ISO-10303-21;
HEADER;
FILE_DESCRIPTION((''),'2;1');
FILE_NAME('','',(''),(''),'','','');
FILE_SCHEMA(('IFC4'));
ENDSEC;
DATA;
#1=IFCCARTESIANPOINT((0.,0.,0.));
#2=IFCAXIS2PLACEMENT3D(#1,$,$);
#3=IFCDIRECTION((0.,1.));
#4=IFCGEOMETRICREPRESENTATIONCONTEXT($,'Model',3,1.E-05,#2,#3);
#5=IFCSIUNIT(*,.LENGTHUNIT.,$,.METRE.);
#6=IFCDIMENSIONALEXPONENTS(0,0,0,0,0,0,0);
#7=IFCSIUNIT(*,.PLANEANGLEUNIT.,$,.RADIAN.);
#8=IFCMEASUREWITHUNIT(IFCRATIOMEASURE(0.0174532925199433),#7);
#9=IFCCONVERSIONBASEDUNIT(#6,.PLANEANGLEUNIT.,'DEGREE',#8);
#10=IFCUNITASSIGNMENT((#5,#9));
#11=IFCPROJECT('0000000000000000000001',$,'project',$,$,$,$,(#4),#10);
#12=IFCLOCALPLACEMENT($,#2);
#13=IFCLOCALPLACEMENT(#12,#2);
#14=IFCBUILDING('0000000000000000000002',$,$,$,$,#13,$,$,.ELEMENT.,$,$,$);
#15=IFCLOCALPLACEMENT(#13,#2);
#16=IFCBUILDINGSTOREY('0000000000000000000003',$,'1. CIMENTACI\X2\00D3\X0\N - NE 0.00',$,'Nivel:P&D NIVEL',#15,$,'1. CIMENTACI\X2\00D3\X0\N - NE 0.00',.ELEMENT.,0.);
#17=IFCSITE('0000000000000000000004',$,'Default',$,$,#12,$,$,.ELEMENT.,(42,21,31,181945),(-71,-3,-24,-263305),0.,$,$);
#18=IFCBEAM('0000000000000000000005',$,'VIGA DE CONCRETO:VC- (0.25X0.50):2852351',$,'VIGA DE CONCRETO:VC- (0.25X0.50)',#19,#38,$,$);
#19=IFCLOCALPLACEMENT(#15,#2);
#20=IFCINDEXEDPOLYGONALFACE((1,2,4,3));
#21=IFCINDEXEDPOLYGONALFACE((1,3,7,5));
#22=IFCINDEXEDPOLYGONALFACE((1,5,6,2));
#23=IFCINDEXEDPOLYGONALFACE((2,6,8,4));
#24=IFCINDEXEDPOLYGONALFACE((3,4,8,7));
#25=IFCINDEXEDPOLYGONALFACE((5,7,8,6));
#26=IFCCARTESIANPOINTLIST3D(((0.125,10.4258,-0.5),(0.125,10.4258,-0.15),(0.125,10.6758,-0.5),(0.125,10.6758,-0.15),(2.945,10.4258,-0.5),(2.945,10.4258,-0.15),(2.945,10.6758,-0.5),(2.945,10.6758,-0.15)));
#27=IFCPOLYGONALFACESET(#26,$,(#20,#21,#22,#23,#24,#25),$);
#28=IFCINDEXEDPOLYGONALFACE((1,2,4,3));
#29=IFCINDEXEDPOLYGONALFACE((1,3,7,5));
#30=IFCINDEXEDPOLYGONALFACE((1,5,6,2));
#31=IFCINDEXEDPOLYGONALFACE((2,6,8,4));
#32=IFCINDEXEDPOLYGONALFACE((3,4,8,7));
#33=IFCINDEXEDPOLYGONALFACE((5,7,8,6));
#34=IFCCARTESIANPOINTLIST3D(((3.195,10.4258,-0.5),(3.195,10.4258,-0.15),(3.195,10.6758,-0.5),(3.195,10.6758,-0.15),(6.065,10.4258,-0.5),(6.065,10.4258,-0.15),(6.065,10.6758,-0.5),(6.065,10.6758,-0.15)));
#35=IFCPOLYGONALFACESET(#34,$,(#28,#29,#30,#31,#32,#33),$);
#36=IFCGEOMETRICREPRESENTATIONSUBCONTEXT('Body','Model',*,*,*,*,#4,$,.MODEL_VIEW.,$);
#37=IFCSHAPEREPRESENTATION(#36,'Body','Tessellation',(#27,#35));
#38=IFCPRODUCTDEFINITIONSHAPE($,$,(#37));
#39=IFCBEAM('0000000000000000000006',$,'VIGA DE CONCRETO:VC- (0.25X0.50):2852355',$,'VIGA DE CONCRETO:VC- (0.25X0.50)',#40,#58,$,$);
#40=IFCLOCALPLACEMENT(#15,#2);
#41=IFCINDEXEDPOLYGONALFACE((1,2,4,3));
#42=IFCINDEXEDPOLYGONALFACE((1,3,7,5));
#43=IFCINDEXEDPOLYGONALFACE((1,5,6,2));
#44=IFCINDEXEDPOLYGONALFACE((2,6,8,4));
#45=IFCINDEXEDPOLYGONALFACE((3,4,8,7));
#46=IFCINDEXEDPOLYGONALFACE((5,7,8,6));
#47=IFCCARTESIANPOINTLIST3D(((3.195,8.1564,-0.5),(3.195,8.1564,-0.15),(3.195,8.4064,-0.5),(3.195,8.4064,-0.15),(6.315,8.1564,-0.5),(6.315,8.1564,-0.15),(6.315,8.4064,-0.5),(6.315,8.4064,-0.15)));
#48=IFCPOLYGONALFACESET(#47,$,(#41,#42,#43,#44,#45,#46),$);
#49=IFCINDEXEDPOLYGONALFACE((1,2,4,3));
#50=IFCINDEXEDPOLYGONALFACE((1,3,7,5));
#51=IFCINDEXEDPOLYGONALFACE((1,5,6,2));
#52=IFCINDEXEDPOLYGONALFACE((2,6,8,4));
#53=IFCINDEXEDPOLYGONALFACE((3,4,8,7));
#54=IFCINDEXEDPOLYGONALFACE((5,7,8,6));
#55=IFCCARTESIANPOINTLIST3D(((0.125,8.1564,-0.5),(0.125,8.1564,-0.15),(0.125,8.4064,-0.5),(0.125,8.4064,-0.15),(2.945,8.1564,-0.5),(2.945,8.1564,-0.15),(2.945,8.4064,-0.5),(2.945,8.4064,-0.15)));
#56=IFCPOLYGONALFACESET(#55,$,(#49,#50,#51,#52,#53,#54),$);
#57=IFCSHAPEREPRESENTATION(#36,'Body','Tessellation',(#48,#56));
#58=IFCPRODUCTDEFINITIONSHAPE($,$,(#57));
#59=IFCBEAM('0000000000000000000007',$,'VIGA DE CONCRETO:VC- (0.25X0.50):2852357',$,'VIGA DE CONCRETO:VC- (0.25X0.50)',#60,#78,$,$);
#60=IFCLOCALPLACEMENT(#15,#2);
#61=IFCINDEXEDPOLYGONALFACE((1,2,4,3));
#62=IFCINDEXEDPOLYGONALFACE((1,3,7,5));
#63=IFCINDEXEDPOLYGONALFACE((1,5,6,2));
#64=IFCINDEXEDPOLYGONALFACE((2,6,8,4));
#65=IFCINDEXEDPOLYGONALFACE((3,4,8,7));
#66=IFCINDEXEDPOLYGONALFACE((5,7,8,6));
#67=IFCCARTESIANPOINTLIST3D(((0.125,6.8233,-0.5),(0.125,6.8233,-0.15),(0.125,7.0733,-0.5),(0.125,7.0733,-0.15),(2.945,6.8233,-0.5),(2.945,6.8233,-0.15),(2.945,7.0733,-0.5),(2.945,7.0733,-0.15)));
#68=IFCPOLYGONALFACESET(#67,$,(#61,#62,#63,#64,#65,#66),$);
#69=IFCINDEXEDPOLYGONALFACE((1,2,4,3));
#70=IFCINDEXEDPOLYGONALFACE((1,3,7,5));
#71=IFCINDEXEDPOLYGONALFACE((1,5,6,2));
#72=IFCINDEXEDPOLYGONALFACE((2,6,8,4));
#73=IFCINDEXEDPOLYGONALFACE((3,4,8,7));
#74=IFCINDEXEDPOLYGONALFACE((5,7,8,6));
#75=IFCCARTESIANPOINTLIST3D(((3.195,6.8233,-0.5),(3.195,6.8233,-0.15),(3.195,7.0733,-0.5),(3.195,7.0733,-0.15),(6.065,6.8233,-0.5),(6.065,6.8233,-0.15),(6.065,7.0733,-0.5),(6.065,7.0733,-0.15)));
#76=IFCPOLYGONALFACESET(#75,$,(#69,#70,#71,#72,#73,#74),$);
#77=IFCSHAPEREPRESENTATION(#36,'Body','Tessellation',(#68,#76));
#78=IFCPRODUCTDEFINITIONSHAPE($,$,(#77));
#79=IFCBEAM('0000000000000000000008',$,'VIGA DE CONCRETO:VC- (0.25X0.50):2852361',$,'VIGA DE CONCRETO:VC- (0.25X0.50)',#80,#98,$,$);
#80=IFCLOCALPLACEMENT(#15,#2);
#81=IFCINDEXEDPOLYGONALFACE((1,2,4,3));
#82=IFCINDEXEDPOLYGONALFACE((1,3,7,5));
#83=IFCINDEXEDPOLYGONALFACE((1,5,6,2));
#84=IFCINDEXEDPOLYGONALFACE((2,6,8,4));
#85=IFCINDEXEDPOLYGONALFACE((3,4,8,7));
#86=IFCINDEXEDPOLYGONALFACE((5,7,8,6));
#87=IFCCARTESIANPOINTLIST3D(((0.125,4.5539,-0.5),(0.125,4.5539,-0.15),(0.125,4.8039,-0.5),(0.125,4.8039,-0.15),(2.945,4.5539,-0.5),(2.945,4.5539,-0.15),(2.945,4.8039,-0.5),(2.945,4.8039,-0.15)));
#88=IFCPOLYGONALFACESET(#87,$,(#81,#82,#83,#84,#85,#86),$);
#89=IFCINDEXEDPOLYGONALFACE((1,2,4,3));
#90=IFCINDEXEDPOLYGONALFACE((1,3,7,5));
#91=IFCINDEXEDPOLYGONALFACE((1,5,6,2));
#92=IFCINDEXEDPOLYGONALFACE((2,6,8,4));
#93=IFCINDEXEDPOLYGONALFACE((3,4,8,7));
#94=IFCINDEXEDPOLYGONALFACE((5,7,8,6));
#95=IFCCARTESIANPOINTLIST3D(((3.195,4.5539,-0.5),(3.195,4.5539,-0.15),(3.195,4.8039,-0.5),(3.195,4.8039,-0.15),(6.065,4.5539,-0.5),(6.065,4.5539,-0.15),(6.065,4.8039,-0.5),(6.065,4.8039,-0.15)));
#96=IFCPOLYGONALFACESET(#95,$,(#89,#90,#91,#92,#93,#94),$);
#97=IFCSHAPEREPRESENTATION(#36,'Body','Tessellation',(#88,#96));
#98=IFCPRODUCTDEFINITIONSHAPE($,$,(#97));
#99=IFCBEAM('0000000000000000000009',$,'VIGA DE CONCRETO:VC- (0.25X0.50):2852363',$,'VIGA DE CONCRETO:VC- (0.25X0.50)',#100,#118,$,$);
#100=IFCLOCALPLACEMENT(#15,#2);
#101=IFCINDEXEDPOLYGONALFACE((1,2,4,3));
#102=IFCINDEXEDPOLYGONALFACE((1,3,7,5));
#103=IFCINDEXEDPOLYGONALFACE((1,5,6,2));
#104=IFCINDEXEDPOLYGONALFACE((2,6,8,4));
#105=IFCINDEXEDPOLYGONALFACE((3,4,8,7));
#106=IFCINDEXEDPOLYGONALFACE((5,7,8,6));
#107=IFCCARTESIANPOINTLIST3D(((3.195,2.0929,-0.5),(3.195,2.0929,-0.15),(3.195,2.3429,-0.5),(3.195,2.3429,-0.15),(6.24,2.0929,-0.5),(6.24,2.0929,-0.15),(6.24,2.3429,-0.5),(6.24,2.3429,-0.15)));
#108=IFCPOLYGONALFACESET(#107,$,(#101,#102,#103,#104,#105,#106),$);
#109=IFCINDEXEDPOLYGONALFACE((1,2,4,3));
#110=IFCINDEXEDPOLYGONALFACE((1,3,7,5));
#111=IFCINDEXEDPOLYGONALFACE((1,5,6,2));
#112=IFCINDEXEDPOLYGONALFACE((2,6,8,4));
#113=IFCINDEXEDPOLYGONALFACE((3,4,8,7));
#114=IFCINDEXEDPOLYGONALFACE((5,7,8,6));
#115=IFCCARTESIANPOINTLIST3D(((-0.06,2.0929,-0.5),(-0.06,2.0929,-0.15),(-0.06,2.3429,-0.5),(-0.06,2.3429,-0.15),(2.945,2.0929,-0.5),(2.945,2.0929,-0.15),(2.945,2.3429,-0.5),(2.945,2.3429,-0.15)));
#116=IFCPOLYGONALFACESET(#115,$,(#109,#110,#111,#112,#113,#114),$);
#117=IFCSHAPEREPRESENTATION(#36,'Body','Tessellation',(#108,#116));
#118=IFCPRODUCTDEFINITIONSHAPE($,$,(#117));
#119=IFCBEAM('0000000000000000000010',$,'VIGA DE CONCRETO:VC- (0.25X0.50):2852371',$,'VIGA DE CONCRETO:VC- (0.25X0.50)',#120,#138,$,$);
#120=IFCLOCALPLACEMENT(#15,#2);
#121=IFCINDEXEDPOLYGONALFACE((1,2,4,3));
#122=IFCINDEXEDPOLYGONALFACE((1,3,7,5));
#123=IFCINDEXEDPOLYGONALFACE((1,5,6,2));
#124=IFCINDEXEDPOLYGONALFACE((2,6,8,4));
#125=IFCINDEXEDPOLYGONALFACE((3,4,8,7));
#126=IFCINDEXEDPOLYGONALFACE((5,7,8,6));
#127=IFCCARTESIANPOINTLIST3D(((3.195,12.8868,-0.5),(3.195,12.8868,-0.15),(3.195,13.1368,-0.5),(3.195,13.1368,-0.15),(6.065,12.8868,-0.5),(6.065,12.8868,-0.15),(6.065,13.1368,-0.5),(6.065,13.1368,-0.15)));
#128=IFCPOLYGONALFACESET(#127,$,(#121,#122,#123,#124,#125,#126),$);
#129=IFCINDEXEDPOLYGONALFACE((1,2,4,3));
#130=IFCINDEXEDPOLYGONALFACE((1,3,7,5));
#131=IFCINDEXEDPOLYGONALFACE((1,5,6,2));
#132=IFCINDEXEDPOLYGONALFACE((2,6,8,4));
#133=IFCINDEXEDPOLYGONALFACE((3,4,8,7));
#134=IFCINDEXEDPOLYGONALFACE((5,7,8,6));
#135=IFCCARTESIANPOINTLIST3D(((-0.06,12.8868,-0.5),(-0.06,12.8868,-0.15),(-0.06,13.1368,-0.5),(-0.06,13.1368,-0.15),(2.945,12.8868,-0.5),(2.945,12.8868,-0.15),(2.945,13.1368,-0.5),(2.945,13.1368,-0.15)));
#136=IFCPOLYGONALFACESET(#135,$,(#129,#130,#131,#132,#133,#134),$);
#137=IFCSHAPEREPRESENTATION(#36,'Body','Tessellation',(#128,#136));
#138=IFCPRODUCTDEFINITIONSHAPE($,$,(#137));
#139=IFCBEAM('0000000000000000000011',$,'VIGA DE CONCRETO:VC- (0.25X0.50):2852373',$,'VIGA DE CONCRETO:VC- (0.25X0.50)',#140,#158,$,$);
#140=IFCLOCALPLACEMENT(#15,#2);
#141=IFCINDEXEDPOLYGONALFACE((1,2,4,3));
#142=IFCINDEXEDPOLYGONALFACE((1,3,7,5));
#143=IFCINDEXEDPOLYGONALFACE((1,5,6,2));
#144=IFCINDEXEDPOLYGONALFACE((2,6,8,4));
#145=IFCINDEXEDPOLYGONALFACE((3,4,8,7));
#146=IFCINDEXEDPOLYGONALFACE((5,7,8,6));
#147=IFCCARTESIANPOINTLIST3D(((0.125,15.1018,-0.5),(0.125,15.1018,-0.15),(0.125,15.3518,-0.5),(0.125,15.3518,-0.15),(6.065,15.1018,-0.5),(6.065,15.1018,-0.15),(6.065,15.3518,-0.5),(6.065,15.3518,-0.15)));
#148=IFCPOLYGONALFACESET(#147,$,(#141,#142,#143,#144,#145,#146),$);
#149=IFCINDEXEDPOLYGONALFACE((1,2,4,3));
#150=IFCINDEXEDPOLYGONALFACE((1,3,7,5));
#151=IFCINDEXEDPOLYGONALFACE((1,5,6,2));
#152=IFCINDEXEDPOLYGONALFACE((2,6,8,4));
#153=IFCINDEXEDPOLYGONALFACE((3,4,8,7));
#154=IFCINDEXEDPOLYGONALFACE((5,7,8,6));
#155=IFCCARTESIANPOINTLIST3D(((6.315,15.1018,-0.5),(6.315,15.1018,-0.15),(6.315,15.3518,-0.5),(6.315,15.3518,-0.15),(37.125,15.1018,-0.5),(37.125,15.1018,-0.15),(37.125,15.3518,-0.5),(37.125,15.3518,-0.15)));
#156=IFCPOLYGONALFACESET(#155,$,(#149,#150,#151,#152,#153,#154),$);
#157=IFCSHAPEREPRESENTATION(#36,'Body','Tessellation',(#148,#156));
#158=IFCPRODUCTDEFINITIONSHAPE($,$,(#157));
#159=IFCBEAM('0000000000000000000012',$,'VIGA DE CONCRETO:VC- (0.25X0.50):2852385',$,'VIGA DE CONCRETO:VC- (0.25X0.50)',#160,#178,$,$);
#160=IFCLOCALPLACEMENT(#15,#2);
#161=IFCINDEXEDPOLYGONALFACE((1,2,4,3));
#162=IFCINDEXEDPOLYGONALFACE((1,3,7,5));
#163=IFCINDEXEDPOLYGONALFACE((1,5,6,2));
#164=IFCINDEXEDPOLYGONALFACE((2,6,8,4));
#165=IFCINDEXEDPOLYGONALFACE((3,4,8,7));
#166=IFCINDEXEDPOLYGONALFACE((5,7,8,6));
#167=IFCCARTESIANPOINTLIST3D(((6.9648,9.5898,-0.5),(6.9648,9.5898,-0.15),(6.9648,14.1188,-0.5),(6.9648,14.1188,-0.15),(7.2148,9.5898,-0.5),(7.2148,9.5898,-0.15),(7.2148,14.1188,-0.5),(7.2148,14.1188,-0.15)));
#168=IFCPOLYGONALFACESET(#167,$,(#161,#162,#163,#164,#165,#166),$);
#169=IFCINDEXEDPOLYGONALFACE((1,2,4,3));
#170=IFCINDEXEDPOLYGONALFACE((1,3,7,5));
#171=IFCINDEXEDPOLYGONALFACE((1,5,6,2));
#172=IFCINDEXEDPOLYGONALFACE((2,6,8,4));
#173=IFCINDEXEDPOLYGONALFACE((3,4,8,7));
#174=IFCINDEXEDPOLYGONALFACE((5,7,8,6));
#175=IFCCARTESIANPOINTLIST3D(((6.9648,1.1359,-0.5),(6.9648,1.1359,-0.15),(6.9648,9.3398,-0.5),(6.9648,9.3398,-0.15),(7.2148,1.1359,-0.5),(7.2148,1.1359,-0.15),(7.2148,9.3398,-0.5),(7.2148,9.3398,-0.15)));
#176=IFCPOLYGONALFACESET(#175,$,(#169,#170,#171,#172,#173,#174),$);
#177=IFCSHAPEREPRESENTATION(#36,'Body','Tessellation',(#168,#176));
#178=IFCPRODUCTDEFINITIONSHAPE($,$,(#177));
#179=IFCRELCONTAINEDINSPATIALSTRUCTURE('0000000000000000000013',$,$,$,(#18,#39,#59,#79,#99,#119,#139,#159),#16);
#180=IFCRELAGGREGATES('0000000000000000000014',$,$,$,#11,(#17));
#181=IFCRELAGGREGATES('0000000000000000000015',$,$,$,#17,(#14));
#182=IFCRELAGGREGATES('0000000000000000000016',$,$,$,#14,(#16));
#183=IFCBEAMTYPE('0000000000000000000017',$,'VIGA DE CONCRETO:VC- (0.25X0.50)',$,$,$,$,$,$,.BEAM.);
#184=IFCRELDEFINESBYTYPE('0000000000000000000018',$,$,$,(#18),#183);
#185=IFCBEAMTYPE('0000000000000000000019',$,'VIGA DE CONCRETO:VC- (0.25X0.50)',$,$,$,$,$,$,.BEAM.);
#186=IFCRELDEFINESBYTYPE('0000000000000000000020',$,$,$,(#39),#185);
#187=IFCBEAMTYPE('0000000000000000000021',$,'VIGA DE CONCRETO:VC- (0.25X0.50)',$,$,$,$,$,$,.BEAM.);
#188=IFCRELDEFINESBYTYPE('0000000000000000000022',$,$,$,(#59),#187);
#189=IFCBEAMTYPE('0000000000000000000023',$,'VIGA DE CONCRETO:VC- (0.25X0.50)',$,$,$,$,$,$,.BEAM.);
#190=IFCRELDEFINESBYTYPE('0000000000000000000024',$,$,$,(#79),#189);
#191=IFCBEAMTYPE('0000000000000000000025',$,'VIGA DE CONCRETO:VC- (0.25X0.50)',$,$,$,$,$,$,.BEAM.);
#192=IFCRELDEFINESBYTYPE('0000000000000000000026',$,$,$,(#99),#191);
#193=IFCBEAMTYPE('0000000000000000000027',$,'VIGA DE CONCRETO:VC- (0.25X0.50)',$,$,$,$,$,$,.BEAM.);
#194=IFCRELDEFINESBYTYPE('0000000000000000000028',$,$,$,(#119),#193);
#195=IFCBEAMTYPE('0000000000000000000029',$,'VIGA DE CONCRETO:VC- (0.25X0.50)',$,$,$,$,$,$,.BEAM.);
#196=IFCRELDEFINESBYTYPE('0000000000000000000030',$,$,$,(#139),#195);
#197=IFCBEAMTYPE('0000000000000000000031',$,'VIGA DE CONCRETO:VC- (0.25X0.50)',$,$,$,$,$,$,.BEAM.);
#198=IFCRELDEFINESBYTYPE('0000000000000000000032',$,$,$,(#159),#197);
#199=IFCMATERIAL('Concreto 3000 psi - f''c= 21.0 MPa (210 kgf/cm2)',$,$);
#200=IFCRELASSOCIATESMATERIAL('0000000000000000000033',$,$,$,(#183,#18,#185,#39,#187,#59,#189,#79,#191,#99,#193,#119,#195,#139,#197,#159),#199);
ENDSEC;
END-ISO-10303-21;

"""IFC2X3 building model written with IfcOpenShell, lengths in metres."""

from ifc_helpers import new_model, entity, si_unit, converted_unit, direction, frame, frame_2d, origin, place, context, subcontext, project, spatial, rectangle, extrude, source, transform, mapped, material, type_object, type_shapes, element, save


model = new_model("IFC2X3")

# Units and contexts
model_context = context("Model", 3, precision=1e-05, world=origin(), true_north=direction((0.0, 1.0)))
body_context = subcontext(model_context, "Body", "Model", "MODEL_VIEW")
ifc_project = project(units=[si_unit("LENGTHUNIT", "METRE"), converted_unit("PLANEANGLEUNIT", "DEGREE", entity("IfcRatioMeasure", 0.0174532925199433), si_unit("PLANEANGLEUNIT", "RADIAN"), dimensions=[0, 0, 0, 0, 0, 0, 0])], contexts=[model_context])

# Site, building, storey
site_placement = place(None, origin())
site = spatial("IfcSite", under=ifc_project, at=site_placement, Name="Default", CompositionType="ELEMENT", RefLatitude=(42, 21, 31, 181945), RefLongitude=(-71, -3, -24, -263305), RefElevation=0.0)
building_placement = place(site_placement, origin())
building = spatial("IfcBuilding", under=site, at=building_placement, CompositionType="ELEMENT")
storey_placement = place(building_placement, origin())
storey = spatial("IfcBuildingStorey", under=building, at=storey_placement, Name="1. CIMENTACIÓN - NE 0.00", ObjectType="Nivel:P&D NIVEL", LongName="1. CIMENTACIÓN - NE 0.00", CompositionType="ELEMENT", Elevation=0.0)

# Beams
ifc_material = material(Name="Concreto 3000 psi - f'c= 21.0 MPa (210 kgf/cm2)")
beam_type_1 = type_object("IfcBeamType", Name="VIGA DE CONCRETO:VC- (0.25X0.50)", PredefinedType="BEAM", material=ifc_material)
shared_shape_1 = source(origin(), body_context, "Body", "SweptSolid", [
    extrude(rectangle(XDim=0.35, YDim=0.25, at=frame_2d((0.0, 0.0), x_axis=(1.0, 0.0))), frame((0.125, 10.5508, -0.325), z_axis=(1.0, 0.0, 0.0), x_axis=(0.0, 0.0, -1.0)), (0.0, 0.0, 1.0), 2.82),
    extrude(rectangle(XDim=0.35, YDim=0.25, at=frame_2d((0.0, 0.0), x_axis=(1.0, 0.0))), frame((3.195, 10.5508, -0.325), z_axis=(1.0, 0.0, 0.0), x_axis=(0.0, 0.0, -1.0)), (0.0, 0.0, 1.0), 2.87),
])
type_shapes(beam_type_1, [shared_shape_1])
beam_1_placement = place(storey_placement, origin())
element("IfcBeam", 1, at=beam_1_placement, inside=storey, type_object=beam_type_1, material=ifc_material, Name="VIGA DE CONCRETO:VC- (0.25X0.50):2852351", ObjectType="VIGA DE CONCRETO:VC- (0.25X0.50)", context=body_context, shape_type="MappedRepresentation", body=[
    mapped(shared_shape_1, transform((0.0, 0.0, 0.0), scale=1.0)),
])
beam_type_2 = type_object("IfcBeamType", Name="VIGA DE CONCRETO:VC- (0.25X0.50)", PredefinedType="BEAM", material=ifc_material)
shared_shape_2 = source(origin(), body_context, "Body", "SweptSolid", [
    extrude(rectangle(XDim=0.35, YDim=0.25, at=frame_2d((0.0, 0.0), x_axis=(1.0, 0.0))), frame((3.195, 8.2814, -0.325), z_axis=(1.0, 0.0, 0.0), x_axis=(0.0, 0.0, -1.0)), (0.0, 0.0, 1.0), 3.12),
    extrude(rectangle(XDim=0.35, YDim=0.25, at=frame_2d((0.0, 0.0), x_axis=(1.0, 0.0))), frame((0.125, 8.2814, -0.325), z_axis=(1.0, 0.0, 0.0), x_axis=(0.0, 0.0, -1.0)), (0.0, 0.0, 1.0), 2.82),
])
type_shapes(beam_type_2, [shared_shape_2])
beam_2_placement = place(storey_placement, origin())
element("IfcBeam", 2, at=beam_2_placement, inside=storey, type_object=beam_type_2, material=ifc_material, Name="VIGA DE CONCRETO:VC- (0.25X0.50):2852355", ObjectType="VIGA DE CONCRETO:VC- (0.25X0.50)", context=body_context, shape_type="MappedRepresentation", body=[
    mapped(shared_shape_2, transform((0.0, 0.0, 0.0), scale=1.0)),
])
beam_type_3 = type_object("IfcBeamType", Name="VIGA DE CONCRETO:VC- (0.25X0.50)", PredefinedType="BEAM", material=ifc_material)
shared_shape_3 = source(origin(), body_context, "Body", "SweptSolid", [
    extrude(rectangle(XDim=0.35, YDim=0.25, at=frame_2d((0.0, 0.0), x_axis=(1.0, 0.0))), frame((0.125, 6.9483, -0.325), z_axis=(1.0, 0.0, 0.0), x_axis=(0.0, 0.0, -1.0)), (0.0, 0.0, 1.0), 2.82),
    extrude(rectangle(XDim=0.35, YDim=0.25, at=frame_2d((0.0, 0.0), x_axis=(1.0, 0.0))), frame((3.195, 6.9483, -0.325), z_axis=(1.0, 0.0, 0.0), x_axis=(0.0, 0.0, -1.0)), (0.0, 0.0, 1.0), 2.87),
])
type_shapes(beam_type_3, [shared_shape_3])
beam_3_placement = place(storey_placement, origin())
element("IfcBeam", 3, at=beam_3_placement, inside=storey, type_object=beam_type_3, material=ifc_material, Name="VIGA DE CONCRETO:VC- (0.25X0.50):2852357", ObjectType="VIGA DE CONCRETO:VC- (0.25X0.50)", context=body_context, shape_type="MappedRepresentation", body=[
    mapped(shared_shape_3, transform((0.0, 0.0, 0.0), scale=1.0)),
])
beam_type_4 = type_object("IfcBeamType", Name="VIGA DE CONCRETO:VC- (0.25X0.50)", PredefinedType="BEAM", material=ifc_material)
shared_shape_4 = source(origin(), body_context, "Body", "SweptSolid", [
    extrude(rectangle(XDim=0.35, YDim=0.25, at=frame_2d((0.0, 0.0), x_axis=(1.0, 0.0))), frame((0.125, 4.6789, -0.325), z_axis=(1.0, 0.0, 0.0), x_axis=(0.0, 0.0, -1.0)), (0.0, 0.0, 1.0), 2.82),
    extrude(rectangle(XDim=0.35, YDim=0.25, at=frame_2d((0.0, 0.0), x_axis=(1.0, 0.0))), frame((3.195, 4.6789, -0.325), z_axis=(1.0, 0.0, 0.0), x_axis=(0.0, 0.0, -1.0)), (0.0, 0.0, 1.0), 2.87),
])
type_shapes(beam_type_4, [shared_shape_4])
beam_4_placement = place(storey_placement, origin())
element("IfcBeam", 4, at=beam_4_placement, inside=storey, type_object=beam_type_4, material=ifc_material, Name="VIGA DE CONCRETO:VC- (0.25X0.50):2852361", ObjectType="VIGA DE CONCRETO:VC- (0.25X0.50)", context=body_context, shape_type="MappedRepresentation", body=[
    mapped(shared_shape_4, transform((0.0, 0.0, 0.0), scale=1.0)),
])
beam_type_5 = type_object("IfcBeamType", Name="VIGA DE CONCRETO:VC- (0.25X0.50)", PredefinedType="BEAM", material=ifc_material)
shared_shape_5 = source(origin(), body_context, "Body", "SweptSolid", [
    extrude(rectangle(XDim=0.35, YDim=0.25, at=frame_2d((0.0, 0.0), x_axis=(1.0, 0.0))), frame((3.195, 2.2179, -0.325), z_axis=(1.0, 0.0, 0.0), x_axis=(0.0, 0.0, -1.0)), (0.0, 0.0, 1.0), 3.045),
    extrude(rectangle(XDim=0.35, YDim=0.25, at=frame_2d((0.0, 0.0), x_axis=(1.0, 0.0))), frame((-0.06, 2.2179, -0.325), z_axis=(1.0, 0.0, 0.0), x_axis=(0.0, 0.0, -1.0)), (0.0, 0.0, 1.0), 3.005),
])
type_shapes(beam_type_5, [shared_shape_5])
beam_5_placement = place(storey_placement, origin())
element("IfcBeam", 5, at=beam_5_placement, inside=storey, type_object=beam_type_5, material=ifc_material, Name="VIGA DE CONCRETO:VC- (0.25X0.50):2852363", ObjectType="VIGA DE CONCRETO:VC- (0.25X0.50)", context=body_context, shape_type="MappedRepresentation", body=[
    mapped(shared_shape_5, transform((0.0, 0.0, 0.0), scale=1.0)),
])
beam_type_6 = type_object("IfcBeamType", Name="VIGA DE CONCRETO:VC- (0.25X0.50)", PredefinedType="BEAM", material=ifc_material)
shared_shape_6 = source(origin(), body_context, "Body", "SweptSolid", [
    extrude(rectangle(XDim=0.35, YDim=0.25, at=frame_2d((0.0, 0.0), x_axis=(1.0, 0.0))), frame((3.195, 13.0118, -0.325), z_axis=(1.0, 0.0, 0.0), x_axis=(0.0, 0.0, -1.0)), (0.0, 0.0, 1.0), 2.87),
    extrude(rectangle(XDim=0.35, YDim=0.25, at=frame_2d((0.0, 0.0), x_axis=(1.0, 0.0))), frame((-0.06, 13.0118, -0.325), z_axis=(1.0, 0.0, 0.0), x_axis=(0.0, 0.0, -1.0)), (0.0, 0.0, 1.0), 3.005),
])
type_shapes(beam_type_6, [shared_shape_6])
beam_6_placement = place(storey_placement, origin())
element("IfcBeam", 6, at=beam_6_placement, inside=storey, type_object=beam_type_6, material=ifc_material, Name="VIGA DE CONCRETO:VC- (0.25X0.50):2852371", ObjectType="VIGA DE CONCRETO:VC- (0.25X0.50)", context=body_context, shape_type="MappedRepresentation", body=[
    mapped(shared_shape_6, transform((0.0, 0.0, 0.0), scale=1.0)),
])
beam_type_7 = type_object("IfcBeamType", Name="VIGA DE CONCRETO:VC- (0.25X0.50)", PredefinedType="BEAM", material=ifc_material)
shared_shape_7 = source(origin(), body_context, "Body", "SweptSolid", [
    extrude(rectangle(XDim=0.35, YDim=0.25, at=frame_2d((0.0, 0.0), x_axis=(1.0, 0.0))), frame((0.125, 15.2268, -0.325), z_axis=(1.0, 0.0, 0.0), x_axis=(0.0, 0.0, -1.0)), (0.0, 0.0, 1.0), 5.94),
    extrude(rectangle(XDim=0.35, YDim=0.25, at=frame_2d((0.0, 0.0), x_axis=(1.0, 0.0))), frame((6.315, 15.2268, -0.325), z_axis=(1.0, 0.0, 0.0), x_axis=(0.0, 0.0, -1.0)), (0.0, 0.0, 1.0), 30.81),
])
type_shapes(beam_type_7, [shared_shape_7])
beam_7_placement = place(storey_placement, origin())
element("IfcBeam", 7, at=beam_7_placement, inside=storey, type_object=beam_type_7, material=ifc_material, Name="VIGA DE CONCRETO:VC- (0.25X0.50):2852373", ObjectType="VIGA DE CONCRETO:VC- (0.25X0.50)", context=body_context, shape_type="MappedRepresentation", body=[
    mapped(shared_shape_7, transform((0.0, 0.0, 0.0), scale=1.0)),
])
beam_type_8 = type_object("IfcBeamType", Name="VIGA DE CONCRETO:VC- (0.25X0.50)", PredefinedType="BEAM", material=ifc_material)
shared_shape_8 = source(origin(), body_context, "Body", "SweptSolid", [
    extrude(rectangle(XDim=0.35, YDim=0.25, at=frame_2d((0.0, 0.0), x_axis=(0.0, 1.0))), frame((7.0898, 14.1188, -0.325), z_axis=(0.0, -1.0, 0.0), x_axis=(-1.0, 0.0, 0.0)), (0.0, 0.0, 1.0), 4.529),
    extrude(rectangle(XDim=0.35, YDim=0.25, at=frame_2d((0.0, 0.0), x_axis=(0.0, 1.0))), frame((7.0898, 9.3398, -0.325), z_axis=(0.0, -1.0, 0.0), x_axis=(-1.0, 0.0, 0.0)), (0.0, 0.0, 1.0), 8.2039),
])
type_shapes(beam_type_8, [shared_shape_8])
beam_8_placement = place(storey_placement, origin())
element("IfcBeam", 8, at=beam_8_placement, inside=storey, type_object=beam_type_8, material=ifc_material, Name="VIGA DE CONCRETO:VC- (0.25X0.50):2852385", ObjectType="VIGA DE CONCRETO:VC- (0.25X0.50)", context=body_context, shape_type="MappedRepresentation", body=[
    mapped(shared_shape_8, transform((0.0, 0.0, 0.0), scale=1.0)),
])

save(model, "model.ifc")
